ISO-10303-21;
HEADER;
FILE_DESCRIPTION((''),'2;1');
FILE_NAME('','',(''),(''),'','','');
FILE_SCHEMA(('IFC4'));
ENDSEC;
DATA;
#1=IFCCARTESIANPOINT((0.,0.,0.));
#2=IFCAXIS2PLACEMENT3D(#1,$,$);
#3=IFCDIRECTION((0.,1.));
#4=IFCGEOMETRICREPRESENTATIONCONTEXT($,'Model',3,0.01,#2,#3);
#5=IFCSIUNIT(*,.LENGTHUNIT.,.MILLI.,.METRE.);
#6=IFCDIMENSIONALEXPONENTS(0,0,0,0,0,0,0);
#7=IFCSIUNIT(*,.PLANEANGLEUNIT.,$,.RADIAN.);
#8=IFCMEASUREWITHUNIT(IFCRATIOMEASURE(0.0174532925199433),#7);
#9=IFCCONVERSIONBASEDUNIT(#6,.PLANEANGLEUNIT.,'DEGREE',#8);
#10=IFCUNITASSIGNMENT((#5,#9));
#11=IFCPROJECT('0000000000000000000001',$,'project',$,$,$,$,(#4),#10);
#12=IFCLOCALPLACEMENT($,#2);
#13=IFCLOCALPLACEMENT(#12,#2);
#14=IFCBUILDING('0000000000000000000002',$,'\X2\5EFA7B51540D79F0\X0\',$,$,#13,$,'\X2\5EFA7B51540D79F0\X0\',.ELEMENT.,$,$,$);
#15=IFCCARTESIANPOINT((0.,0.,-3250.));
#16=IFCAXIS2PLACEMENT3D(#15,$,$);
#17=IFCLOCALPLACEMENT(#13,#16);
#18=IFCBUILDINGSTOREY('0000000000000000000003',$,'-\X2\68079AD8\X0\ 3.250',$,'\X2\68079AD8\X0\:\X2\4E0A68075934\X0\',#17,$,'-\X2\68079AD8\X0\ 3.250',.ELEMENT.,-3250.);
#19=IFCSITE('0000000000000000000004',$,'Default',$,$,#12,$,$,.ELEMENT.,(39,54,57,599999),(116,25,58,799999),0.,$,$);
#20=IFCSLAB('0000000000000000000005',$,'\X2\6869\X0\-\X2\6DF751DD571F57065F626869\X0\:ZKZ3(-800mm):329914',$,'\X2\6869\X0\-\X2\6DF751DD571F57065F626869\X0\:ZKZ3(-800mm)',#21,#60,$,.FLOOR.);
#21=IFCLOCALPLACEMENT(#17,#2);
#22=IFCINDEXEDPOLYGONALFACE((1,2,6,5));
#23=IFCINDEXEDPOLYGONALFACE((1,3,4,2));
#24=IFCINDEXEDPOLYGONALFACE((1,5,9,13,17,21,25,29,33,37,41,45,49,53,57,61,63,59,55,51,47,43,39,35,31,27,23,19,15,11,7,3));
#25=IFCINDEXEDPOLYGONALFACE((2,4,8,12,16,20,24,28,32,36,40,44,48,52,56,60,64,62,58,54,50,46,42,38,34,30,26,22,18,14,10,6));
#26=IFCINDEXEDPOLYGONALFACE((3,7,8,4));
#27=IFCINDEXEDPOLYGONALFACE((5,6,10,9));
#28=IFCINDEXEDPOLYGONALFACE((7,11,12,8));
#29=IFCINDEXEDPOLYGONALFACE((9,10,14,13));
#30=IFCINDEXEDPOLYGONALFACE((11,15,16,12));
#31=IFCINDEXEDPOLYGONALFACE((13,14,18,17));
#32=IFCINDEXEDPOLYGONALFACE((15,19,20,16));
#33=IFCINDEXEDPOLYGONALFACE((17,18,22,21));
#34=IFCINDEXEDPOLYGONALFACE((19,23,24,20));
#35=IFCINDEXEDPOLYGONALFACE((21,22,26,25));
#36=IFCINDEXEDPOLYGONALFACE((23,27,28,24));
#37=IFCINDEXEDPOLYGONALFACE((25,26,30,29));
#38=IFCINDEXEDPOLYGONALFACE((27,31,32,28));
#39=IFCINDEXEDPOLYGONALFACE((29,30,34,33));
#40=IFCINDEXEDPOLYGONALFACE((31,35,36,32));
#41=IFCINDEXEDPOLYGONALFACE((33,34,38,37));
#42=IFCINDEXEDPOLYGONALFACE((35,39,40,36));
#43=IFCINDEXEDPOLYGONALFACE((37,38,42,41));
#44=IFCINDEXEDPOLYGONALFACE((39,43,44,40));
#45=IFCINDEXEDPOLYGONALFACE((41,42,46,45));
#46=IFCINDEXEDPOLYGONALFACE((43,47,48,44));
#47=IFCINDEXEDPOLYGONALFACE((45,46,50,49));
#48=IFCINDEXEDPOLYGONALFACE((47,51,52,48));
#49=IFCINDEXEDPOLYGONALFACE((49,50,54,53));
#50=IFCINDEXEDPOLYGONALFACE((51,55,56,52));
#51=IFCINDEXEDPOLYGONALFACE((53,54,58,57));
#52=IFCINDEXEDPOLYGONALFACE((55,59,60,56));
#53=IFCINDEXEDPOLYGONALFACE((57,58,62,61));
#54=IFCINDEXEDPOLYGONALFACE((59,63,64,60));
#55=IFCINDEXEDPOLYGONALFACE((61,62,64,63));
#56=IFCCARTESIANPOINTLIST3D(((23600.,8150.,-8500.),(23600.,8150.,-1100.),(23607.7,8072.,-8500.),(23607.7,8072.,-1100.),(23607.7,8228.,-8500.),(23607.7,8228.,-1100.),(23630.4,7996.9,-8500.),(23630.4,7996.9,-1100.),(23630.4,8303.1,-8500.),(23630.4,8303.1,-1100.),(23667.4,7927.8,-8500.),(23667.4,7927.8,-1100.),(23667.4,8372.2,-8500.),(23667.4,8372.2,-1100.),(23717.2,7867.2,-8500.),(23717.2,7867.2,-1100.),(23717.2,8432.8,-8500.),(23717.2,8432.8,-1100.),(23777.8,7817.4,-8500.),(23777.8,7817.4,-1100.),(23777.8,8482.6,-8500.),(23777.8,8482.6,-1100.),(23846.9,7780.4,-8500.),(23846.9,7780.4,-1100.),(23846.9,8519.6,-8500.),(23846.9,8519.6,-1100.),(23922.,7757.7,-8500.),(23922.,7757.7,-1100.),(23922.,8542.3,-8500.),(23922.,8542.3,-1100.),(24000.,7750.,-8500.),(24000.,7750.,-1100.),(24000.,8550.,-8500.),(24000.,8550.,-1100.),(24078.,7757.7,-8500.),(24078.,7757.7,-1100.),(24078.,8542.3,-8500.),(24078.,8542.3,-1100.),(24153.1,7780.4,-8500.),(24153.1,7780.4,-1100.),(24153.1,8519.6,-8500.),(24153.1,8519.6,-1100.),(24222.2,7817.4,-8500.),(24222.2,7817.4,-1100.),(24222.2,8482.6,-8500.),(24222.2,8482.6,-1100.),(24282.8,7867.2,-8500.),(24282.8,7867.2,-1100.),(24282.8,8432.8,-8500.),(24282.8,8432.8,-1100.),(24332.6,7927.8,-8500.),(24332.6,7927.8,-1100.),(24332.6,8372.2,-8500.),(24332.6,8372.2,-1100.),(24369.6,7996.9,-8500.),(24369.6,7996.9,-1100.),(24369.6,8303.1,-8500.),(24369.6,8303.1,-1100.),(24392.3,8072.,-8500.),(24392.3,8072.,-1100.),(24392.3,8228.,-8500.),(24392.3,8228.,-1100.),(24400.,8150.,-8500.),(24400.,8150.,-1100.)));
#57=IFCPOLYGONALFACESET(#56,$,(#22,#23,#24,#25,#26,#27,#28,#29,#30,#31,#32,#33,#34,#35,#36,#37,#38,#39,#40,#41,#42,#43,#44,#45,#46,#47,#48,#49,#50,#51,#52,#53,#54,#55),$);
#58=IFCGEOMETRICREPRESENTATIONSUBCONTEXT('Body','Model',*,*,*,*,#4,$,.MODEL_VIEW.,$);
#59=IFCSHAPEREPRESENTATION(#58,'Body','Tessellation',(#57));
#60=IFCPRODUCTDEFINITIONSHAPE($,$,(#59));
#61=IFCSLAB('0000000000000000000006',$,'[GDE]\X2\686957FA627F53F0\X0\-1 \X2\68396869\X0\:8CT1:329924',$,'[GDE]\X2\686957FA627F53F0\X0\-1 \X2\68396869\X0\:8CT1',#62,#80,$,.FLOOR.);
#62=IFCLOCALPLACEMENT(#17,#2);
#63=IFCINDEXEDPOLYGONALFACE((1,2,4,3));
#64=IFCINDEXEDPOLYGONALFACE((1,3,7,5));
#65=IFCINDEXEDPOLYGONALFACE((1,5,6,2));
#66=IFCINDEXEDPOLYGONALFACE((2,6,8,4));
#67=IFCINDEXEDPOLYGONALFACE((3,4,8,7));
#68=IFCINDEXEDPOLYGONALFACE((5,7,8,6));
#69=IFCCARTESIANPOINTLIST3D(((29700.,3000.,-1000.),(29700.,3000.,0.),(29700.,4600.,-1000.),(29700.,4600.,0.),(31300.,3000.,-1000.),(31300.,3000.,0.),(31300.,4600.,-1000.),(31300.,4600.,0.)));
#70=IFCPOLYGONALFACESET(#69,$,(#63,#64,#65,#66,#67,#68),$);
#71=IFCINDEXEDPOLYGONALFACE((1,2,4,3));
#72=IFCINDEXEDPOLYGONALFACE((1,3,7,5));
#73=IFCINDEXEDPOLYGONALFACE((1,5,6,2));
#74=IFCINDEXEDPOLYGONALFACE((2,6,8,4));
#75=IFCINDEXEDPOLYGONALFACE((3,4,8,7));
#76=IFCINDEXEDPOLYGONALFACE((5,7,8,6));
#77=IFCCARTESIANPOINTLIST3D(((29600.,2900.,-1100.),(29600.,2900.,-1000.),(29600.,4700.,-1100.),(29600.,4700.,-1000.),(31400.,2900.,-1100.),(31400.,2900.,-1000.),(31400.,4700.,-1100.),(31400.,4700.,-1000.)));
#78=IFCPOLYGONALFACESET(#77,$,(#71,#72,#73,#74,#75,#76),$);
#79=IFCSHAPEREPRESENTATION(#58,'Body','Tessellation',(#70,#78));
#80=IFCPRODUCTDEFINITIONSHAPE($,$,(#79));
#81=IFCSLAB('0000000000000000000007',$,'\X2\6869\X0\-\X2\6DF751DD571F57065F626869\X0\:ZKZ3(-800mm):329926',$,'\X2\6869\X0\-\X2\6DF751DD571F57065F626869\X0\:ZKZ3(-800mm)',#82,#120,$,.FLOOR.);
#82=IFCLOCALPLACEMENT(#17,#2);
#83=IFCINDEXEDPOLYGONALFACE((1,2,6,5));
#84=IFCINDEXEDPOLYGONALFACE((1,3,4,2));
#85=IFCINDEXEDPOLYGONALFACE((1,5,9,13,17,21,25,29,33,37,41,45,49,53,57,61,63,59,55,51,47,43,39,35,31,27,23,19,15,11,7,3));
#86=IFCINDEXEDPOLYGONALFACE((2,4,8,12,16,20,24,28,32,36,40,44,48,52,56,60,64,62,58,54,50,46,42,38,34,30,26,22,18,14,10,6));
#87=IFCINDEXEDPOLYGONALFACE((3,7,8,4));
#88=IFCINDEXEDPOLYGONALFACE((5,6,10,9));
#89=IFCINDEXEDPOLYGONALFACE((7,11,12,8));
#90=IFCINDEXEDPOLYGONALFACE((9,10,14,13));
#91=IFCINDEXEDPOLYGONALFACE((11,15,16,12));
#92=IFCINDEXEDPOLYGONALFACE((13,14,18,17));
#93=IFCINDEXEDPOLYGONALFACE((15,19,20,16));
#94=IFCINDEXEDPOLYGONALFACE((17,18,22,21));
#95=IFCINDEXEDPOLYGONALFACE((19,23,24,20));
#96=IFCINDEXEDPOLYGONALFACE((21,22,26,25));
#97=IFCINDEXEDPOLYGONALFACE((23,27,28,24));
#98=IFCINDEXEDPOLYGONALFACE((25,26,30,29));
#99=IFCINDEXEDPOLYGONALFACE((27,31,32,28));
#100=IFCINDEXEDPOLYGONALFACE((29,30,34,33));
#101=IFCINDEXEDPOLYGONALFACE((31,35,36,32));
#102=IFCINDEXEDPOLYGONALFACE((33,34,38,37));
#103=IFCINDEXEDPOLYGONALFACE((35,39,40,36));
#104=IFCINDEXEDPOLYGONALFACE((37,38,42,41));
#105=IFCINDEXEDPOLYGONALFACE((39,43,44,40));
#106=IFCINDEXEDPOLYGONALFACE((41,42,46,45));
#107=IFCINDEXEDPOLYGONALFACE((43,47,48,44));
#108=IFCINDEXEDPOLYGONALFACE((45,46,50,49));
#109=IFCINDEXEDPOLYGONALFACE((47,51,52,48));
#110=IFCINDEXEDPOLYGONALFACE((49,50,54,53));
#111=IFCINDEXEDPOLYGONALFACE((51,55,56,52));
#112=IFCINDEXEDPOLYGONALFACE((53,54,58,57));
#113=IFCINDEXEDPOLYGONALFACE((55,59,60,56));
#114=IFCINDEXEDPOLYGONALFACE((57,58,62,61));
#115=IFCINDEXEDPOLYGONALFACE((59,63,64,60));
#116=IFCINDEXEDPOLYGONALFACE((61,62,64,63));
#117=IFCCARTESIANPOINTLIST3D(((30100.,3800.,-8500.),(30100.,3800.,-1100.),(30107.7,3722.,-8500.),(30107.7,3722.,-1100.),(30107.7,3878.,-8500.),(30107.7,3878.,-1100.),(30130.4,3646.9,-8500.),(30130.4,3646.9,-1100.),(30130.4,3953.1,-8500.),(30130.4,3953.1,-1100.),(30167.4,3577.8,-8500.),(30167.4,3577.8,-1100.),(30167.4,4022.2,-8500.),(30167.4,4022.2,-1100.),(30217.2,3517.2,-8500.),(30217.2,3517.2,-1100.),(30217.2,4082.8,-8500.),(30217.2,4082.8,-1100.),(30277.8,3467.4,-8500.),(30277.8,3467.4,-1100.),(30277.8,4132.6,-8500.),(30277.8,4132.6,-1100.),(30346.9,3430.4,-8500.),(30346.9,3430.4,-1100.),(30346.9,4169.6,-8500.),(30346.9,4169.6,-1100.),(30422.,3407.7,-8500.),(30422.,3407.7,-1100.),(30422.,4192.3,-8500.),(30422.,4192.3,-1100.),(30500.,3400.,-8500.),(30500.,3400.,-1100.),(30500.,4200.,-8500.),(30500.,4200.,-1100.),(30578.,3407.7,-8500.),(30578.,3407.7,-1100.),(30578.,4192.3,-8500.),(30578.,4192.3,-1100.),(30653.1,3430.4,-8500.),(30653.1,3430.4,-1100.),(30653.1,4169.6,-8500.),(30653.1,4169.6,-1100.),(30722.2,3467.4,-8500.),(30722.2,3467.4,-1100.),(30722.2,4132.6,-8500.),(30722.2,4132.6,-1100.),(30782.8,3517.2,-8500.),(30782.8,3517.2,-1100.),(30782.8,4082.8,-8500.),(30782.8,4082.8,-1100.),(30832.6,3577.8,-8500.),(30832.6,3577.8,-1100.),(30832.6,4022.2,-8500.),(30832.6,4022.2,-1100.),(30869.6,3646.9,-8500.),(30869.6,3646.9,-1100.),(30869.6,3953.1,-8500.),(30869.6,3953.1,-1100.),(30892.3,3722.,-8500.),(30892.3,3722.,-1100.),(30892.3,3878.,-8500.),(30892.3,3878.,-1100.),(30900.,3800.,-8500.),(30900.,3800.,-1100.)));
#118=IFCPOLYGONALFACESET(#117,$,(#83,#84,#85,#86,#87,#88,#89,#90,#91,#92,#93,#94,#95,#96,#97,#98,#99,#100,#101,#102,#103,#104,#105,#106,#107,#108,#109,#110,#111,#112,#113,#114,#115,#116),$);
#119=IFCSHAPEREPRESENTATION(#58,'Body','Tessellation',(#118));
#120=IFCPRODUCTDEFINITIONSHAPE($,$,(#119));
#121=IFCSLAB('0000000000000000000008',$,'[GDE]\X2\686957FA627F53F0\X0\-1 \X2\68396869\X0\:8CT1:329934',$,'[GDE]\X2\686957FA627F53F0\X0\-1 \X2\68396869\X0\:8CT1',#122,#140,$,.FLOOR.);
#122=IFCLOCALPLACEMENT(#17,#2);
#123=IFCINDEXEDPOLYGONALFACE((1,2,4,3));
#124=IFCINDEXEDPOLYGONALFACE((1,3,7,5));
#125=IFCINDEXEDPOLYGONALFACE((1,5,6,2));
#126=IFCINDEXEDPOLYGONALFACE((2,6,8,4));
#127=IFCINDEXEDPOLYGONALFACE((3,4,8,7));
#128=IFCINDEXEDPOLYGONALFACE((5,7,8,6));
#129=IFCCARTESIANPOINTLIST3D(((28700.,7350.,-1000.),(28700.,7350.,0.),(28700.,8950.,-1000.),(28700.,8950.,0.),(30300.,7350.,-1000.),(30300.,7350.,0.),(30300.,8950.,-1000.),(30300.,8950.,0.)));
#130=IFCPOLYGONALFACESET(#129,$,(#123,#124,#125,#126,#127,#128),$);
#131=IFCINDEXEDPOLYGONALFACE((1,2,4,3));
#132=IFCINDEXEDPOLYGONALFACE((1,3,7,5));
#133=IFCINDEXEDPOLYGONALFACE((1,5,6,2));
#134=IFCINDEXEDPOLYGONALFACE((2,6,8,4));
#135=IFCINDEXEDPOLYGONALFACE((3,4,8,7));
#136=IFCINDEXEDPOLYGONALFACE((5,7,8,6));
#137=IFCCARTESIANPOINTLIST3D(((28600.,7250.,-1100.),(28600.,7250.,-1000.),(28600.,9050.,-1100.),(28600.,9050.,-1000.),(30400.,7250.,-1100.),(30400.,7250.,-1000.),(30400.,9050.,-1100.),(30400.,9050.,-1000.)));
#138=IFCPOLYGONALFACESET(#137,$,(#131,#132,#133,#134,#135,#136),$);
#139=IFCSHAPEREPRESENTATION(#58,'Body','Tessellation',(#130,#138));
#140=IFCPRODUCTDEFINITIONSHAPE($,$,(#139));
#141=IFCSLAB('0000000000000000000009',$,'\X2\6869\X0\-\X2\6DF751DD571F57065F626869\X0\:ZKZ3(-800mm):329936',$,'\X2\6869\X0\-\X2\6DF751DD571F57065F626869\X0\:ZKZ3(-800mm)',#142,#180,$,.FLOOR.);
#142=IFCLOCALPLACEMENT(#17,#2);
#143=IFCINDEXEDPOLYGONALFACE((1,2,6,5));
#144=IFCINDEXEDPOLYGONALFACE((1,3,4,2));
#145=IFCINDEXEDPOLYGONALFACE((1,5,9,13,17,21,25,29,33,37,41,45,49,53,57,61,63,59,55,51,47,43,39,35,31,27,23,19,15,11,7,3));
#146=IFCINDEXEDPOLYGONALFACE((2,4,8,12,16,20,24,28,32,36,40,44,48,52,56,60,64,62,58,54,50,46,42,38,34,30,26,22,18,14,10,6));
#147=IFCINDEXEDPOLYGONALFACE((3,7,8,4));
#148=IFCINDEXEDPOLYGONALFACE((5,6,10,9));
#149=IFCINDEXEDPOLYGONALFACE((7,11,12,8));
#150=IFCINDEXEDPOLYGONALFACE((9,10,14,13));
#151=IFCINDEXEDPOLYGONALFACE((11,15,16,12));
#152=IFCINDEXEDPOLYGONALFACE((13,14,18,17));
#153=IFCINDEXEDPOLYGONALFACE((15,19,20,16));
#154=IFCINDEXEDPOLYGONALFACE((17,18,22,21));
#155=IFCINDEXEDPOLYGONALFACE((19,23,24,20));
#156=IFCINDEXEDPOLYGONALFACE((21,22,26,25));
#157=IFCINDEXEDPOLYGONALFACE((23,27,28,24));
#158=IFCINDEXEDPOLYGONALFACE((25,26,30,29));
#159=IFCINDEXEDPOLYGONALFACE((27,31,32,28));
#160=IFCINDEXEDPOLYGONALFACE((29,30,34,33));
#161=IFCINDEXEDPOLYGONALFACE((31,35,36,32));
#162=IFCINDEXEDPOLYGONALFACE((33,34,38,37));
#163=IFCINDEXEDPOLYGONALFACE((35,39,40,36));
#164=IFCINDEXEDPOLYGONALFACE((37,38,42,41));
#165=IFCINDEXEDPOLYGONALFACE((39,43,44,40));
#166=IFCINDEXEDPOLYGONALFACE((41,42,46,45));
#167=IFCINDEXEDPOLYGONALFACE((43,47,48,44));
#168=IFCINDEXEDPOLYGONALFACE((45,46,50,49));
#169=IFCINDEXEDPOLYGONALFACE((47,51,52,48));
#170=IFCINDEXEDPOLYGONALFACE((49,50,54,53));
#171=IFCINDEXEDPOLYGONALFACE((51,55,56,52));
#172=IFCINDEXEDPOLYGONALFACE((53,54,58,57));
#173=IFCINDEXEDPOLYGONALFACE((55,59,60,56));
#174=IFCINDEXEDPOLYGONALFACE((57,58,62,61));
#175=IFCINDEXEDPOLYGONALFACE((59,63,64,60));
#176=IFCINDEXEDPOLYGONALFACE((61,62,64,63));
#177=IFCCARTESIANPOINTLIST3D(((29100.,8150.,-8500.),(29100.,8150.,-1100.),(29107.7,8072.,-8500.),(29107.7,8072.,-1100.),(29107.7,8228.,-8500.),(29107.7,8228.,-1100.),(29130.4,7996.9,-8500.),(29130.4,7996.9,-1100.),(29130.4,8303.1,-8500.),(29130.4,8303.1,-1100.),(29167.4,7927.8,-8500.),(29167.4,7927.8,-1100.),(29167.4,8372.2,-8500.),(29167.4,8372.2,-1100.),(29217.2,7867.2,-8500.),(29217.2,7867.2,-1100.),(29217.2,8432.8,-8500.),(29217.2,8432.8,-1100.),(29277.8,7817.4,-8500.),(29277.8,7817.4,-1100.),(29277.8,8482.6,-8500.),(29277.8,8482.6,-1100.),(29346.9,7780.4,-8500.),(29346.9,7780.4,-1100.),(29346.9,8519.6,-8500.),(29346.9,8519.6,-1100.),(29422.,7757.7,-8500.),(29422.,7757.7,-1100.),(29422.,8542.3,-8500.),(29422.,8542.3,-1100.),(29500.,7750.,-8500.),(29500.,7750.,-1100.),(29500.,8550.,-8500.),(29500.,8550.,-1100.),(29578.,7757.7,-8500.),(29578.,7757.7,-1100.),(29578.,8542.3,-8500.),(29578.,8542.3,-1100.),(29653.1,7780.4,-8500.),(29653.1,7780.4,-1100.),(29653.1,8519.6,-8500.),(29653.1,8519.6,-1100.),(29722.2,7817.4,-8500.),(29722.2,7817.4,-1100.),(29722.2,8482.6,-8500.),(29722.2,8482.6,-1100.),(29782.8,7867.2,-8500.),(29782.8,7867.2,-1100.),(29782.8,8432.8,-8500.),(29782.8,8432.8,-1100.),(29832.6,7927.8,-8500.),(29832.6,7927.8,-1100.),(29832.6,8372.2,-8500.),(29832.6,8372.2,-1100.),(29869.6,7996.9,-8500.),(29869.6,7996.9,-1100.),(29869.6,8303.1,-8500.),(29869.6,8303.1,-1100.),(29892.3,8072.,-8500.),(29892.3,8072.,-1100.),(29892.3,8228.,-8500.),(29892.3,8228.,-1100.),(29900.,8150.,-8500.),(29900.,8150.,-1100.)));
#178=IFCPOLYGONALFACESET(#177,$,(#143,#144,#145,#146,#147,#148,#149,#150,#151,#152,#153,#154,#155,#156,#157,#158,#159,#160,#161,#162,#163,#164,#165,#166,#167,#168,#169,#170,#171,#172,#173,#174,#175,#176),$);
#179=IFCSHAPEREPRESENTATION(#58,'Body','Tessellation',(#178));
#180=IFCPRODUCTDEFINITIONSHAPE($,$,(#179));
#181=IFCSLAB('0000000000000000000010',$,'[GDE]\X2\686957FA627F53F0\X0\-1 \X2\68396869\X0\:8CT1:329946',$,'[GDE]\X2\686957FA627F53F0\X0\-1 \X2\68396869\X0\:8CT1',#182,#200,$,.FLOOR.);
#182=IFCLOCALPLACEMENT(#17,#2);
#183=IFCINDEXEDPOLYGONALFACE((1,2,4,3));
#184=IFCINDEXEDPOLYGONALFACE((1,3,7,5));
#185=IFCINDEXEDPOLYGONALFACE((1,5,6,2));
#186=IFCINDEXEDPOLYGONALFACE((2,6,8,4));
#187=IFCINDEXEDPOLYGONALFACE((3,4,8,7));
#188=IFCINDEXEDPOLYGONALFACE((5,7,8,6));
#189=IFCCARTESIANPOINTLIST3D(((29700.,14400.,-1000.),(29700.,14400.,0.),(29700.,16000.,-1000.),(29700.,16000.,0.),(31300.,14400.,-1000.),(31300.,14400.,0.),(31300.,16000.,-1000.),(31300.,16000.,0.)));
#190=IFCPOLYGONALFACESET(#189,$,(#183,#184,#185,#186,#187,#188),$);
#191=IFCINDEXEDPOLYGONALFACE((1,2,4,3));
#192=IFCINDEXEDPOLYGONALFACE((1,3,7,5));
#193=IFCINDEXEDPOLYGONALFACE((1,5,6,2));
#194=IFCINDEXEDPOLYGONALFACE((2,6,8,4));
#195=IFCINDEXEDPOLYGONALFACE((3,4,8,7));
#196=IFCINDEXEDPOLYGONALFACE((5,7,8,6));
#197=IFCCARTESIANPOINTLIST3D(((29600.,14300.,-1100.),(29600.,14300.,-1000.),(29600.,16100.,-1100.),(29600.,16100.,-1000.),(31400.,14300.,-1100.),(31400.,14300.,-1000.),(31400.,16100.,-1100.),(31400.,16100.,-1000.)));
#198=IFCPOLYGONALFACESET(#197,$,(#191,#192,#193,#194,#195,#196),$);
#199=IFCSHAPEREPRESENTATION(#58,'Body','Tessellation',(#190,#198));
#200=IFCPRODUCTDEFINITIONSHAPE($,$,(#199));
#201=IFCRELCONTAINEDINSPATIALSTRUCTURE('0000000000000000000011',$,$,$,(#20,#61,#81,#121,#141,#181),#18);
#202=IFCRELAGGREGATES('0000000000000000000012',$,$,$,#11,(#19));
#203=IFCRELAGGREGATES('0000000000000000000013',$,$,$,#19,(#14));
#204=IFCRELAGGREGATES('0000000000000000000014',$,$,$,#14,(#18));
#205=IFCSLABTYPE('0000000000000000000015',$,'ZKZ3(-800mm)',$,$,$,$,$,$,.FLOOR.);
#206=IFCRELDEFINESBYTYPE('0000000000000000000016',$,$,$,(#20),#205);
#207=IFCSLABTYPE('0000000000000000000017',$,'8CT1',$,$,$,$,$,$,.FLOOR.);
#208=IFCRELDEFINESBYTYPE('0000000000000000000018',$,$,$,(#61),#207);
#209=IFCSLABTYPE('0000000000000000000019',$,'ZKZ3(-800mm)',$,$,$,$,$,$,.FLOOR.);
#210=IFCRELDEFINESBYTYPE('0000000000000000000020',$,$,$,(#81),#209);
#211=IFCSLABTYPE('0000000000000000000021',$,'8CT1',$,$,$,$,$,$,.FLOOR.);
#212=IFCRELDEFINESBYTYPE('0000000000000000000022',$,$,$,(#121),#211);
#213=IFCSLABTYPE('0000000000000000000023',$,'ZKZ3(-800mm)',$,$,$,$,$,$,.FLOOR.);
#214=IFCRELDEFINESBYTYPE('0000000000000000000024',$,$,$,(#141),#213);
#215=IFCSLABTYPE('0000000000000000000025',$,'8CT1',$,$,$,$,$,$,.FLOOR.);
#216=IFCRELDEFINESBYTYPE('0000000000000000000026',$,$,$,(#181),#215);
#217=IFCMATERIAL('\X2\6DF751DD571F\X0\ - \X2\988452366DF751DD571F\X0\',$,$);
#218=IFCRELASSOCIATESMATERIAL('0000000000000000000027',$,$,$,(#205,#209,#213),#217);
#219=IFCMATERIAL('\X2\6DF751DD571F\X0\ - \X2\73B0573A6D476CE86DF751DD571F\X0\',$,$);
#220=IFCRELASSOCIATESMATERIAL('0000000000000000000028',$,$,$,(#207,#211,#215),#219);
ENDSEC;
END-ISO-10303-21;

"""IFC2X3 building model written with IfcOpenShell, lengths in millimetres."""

from ifc_helpers import new_model, entity, si_unit, converted_unit, direction, frame, frame_2d, origin, origin_2d_with_axis, place, context, subcontext, project, spatial, rectangle, circle, extrude, material, type_object, element, save


model = new_model("IFC2X3")

# Units and contexts
model_context = context("Model", 3, precision=0.01, world=origin(), true_north=direction((0.0, 1.0)))
body_context = subcontext(model_context, "Body", "Model", "MODEL_VIEW")
ifc_project = project(units=[si_unit("LENGTHUNIT", "METRE", prefix="MILLI"), converted_unit("PLANEANGLEUNIT", "DEGREE", entity("IfcRatioMeasure", 0.0174532925199433), si_unit("PLANEANGLEUNIT", "RADIAN"), dimensions=[0, 0, 0, 0, 0, 0, 0])], contexts=[model_context])

# Site, building, storey
site_placement = place(None, origin())
site = spatial("IfcSite", under=ifc_project, at=site_placement, Name="Default", CompositionType="ELEMENT", RefLatitude=(39, 54, 57, 599999), RefLongitude=(116, 25, 58, 799999), RefElevation=0.0)
building_placement = place(site_placement, origin())
building = spatial("IfcBuilding", under=site, at=building_placement, Name="建筑名称", LongName="建筑名称", CompositionType="ELEMENT")
storey_placement = place(building_placement, frame((0.0, 0.0, -3250.0)))
storey = spatial("IfcBuildingStorey", under=building, at=storey_placement, Name="-标高 3.250", ObjectType="标高:上标头", LongName="-标高 3.250", CompositionType="ELEMENT", Elevation=-3250.0)

# Slabs
ifc_material_1 = material(Name="混凝土 - 现场浇注混凝土")
ifc_material_2 = material(Name="混凝土 - 预制混凝土")
slab_type_1 = type_object("IfcSlabType", Name="ZKZ3(-800mm)", PredefinedType="FLOOR", material=ifc_material_2)
slab_1_placement = place(storey_placement, origin())
element("IfcSlab", 1, at=slab_1_placement, inside=storey, type_object=slab_type_1, Name="桩-混凝土圆形桩:ZKZ3(-800mm):329914", ObjectType="桩-混凝土圆形桩:ZKZ3(-800mm)", PredefinedType="FLOOR", context=body_context, shape_type="SweptSolid", body=[
    extrude(circle(Radius=400.0, at=origin_2d_with_axis()), frame((24000.0, 8150.0, -8500.0)), (0.0, 0.0, 1.0), 7400.0),
])
slab_type_2 = type_object("IfcSlabType", Name="8CT1", PredefinedType="FLOOR", material=ifc_material_1)
slab_2_placement = place(storey_placement, origin())
element("IfcSlab", 2, at=slab_2_placement, inside=storey, type_object=slab_type_2, Name="[GDE]桩基承台-1 根桩:8CT1:329924", ObjectType="[GDE]桩基承台-1 根桩:8CT1", PredefinedType="FLOOR", context=body_context, shape_type="SweptSolid", body=[
    extrude(rectangle(XDim=1600.0, YDim=1600.0, at=origin_2d_with_axis()), frame((30500.0, 3800.0, -1000.0), z_axis=(0.0, 0.0, 1.0), x_axis=(-1.0, 0.0, 0.0)), (0.0, 0.0, 1.0), 1000.0),
    extrude(rectangle(XDim=1800.0, YDim=1800.0, at=origin_2d_with_axis()), frame((30500.0, 3800.0, -1100.0), z_axis=(0.0, 0.0, 1.0), x_axis=(-1.0, 0.0, 0.0)), (0.0, 0.0, 1.0), 100.0),
])
slab_type_3 = type_object("IfcSlabType", Name="ZKZ3(-800mm)", PredefinedType="FLOOR", material=ifc_material_2)
slab_3_placement = place(storey_placement, origin())
element("IfcSlab", 3, at=slab_3_placement, inside=storey, type_object=slab_type_3, Name="桩-混凝土圆形桩:ZKZ3(-800mm):329926", ObjectType="桩-混凝土圆形桩:ZKZ3(-800mm)", PredefinedType="FLOOR", context=body_context, shape_type="SweptSolid", body=[
    extrude(circle(Radius=400.0, at=frame_2d((0.0, 0.0), x_axis=(1.0, 0.0))), frame((30500.0, 3800.0, -8500.0)), (0.0, 0.0, 1.0), 7400.0),
])
slab_type_4 = type_object("IfcSlabType", Name="8CT1", PredefinedType="FLOOR", material=ifc_material_1)
slab_4_placement = place(storey_placement, origin())
element("IfcSlab", 4, at=slab_4_placement, inside=storey, type_object=slab_type_4, Name="[GDE]桩基承台-1 根桩:8CT1:329934", ObjectType="[GDE]桩基承台-1 根桩:8CT1", PredefinedType="FLOOR", context=body_context, shape_type="SweptSolid", body=[
    extrude(rectangle(XDim=1600.0, YDim=1600.0, at=origin_2d_with_axis()), frame((29500.0, 8150.0, -1000.0), z_axis=(0.0, 0.0, 1.0), x_axis=(-1.0, 0.0, 0.0)), (0.0, 0.0, 1.0), 1000.0),
    extrude(rectangle(XDim=1800.0, YDim=1800.0, at=frame_2d((0.0, 0.0), x_axis=(1.0, 0.0))), frame((29500.0, 8150.0, -1100.0), z_axis=(0.0, 0.0, 1.0), x_axis=(-1.0, 0.0, 0.0)), (0.0, 0.0, 1.0), 100.0),
])
slab_type_5 = type_object("IfcSlabType", Name="ZKZ3(-800mm)", PredefinedType="FLOOR", material=ifc_material_2)
slab_5_placement = place(storey_placement, origin())
element("IfcSlab", 5, at=slab_5_placement, inside=storey, type_object=slab_type_5, Name="桩-混凝土圆形桩:ZKZ3(-800mm):329936", ObjectType="桩-混凝土圆形桩:ZKZ3(-800mm)", PredefinedType="FLOOR", context=body_context, shape_type="SweptSolid", body=[
    extrude(circle(Radius=400.0, at=origin_2d_with_axis()), frame((29500.0, 8150.0, -8500.0)), (0.0, 0.0, 1.0), 7400.0),
])
slab_type_6 = type_object("IfcSlabType", Name="8CT1", PredefinedType="FLOOR", material=ifc_material_1)
slab_6_placement = place(storey_placement, origin())
element("IfcSlab", 6, at=slab_6_placement, inside=storey, type_object=slab_type_6, Name="[GDE]桩基承台-1 根桩:8CT1:329946", ObjectType="[GDE]桩基承台-1 根桩:8CT1", PredefinedType="FLOOR", context=body_context, shape_type="SweptSolid", body=[
    extrude(rectangle(XDim=1600.0, YDim=1600.0, at=origin_2d_with_axis()), frame((30500.0, 15200.0, -1000.0), z_axis=(0.0, 0.0, 1.0), x_axis=(-1.0, 0.0, 0.0)), (0.0, 0.0, 1.0), 1000.0),
    extrude(rectangle(XDim=1800.0, YDim=1800.0, at=frame_2d((0.0, 0.0), x_axis=(1.0, 0.0))), frame((30500.0, 15200.0, -1100.0), z_axis=(0.0, 0.0, 1.0), x_axis=(-1.0, 0.0, 0.0)), (0.0, 0.0, 1.0), 100.0),
])

save(model, "model.ifc")
